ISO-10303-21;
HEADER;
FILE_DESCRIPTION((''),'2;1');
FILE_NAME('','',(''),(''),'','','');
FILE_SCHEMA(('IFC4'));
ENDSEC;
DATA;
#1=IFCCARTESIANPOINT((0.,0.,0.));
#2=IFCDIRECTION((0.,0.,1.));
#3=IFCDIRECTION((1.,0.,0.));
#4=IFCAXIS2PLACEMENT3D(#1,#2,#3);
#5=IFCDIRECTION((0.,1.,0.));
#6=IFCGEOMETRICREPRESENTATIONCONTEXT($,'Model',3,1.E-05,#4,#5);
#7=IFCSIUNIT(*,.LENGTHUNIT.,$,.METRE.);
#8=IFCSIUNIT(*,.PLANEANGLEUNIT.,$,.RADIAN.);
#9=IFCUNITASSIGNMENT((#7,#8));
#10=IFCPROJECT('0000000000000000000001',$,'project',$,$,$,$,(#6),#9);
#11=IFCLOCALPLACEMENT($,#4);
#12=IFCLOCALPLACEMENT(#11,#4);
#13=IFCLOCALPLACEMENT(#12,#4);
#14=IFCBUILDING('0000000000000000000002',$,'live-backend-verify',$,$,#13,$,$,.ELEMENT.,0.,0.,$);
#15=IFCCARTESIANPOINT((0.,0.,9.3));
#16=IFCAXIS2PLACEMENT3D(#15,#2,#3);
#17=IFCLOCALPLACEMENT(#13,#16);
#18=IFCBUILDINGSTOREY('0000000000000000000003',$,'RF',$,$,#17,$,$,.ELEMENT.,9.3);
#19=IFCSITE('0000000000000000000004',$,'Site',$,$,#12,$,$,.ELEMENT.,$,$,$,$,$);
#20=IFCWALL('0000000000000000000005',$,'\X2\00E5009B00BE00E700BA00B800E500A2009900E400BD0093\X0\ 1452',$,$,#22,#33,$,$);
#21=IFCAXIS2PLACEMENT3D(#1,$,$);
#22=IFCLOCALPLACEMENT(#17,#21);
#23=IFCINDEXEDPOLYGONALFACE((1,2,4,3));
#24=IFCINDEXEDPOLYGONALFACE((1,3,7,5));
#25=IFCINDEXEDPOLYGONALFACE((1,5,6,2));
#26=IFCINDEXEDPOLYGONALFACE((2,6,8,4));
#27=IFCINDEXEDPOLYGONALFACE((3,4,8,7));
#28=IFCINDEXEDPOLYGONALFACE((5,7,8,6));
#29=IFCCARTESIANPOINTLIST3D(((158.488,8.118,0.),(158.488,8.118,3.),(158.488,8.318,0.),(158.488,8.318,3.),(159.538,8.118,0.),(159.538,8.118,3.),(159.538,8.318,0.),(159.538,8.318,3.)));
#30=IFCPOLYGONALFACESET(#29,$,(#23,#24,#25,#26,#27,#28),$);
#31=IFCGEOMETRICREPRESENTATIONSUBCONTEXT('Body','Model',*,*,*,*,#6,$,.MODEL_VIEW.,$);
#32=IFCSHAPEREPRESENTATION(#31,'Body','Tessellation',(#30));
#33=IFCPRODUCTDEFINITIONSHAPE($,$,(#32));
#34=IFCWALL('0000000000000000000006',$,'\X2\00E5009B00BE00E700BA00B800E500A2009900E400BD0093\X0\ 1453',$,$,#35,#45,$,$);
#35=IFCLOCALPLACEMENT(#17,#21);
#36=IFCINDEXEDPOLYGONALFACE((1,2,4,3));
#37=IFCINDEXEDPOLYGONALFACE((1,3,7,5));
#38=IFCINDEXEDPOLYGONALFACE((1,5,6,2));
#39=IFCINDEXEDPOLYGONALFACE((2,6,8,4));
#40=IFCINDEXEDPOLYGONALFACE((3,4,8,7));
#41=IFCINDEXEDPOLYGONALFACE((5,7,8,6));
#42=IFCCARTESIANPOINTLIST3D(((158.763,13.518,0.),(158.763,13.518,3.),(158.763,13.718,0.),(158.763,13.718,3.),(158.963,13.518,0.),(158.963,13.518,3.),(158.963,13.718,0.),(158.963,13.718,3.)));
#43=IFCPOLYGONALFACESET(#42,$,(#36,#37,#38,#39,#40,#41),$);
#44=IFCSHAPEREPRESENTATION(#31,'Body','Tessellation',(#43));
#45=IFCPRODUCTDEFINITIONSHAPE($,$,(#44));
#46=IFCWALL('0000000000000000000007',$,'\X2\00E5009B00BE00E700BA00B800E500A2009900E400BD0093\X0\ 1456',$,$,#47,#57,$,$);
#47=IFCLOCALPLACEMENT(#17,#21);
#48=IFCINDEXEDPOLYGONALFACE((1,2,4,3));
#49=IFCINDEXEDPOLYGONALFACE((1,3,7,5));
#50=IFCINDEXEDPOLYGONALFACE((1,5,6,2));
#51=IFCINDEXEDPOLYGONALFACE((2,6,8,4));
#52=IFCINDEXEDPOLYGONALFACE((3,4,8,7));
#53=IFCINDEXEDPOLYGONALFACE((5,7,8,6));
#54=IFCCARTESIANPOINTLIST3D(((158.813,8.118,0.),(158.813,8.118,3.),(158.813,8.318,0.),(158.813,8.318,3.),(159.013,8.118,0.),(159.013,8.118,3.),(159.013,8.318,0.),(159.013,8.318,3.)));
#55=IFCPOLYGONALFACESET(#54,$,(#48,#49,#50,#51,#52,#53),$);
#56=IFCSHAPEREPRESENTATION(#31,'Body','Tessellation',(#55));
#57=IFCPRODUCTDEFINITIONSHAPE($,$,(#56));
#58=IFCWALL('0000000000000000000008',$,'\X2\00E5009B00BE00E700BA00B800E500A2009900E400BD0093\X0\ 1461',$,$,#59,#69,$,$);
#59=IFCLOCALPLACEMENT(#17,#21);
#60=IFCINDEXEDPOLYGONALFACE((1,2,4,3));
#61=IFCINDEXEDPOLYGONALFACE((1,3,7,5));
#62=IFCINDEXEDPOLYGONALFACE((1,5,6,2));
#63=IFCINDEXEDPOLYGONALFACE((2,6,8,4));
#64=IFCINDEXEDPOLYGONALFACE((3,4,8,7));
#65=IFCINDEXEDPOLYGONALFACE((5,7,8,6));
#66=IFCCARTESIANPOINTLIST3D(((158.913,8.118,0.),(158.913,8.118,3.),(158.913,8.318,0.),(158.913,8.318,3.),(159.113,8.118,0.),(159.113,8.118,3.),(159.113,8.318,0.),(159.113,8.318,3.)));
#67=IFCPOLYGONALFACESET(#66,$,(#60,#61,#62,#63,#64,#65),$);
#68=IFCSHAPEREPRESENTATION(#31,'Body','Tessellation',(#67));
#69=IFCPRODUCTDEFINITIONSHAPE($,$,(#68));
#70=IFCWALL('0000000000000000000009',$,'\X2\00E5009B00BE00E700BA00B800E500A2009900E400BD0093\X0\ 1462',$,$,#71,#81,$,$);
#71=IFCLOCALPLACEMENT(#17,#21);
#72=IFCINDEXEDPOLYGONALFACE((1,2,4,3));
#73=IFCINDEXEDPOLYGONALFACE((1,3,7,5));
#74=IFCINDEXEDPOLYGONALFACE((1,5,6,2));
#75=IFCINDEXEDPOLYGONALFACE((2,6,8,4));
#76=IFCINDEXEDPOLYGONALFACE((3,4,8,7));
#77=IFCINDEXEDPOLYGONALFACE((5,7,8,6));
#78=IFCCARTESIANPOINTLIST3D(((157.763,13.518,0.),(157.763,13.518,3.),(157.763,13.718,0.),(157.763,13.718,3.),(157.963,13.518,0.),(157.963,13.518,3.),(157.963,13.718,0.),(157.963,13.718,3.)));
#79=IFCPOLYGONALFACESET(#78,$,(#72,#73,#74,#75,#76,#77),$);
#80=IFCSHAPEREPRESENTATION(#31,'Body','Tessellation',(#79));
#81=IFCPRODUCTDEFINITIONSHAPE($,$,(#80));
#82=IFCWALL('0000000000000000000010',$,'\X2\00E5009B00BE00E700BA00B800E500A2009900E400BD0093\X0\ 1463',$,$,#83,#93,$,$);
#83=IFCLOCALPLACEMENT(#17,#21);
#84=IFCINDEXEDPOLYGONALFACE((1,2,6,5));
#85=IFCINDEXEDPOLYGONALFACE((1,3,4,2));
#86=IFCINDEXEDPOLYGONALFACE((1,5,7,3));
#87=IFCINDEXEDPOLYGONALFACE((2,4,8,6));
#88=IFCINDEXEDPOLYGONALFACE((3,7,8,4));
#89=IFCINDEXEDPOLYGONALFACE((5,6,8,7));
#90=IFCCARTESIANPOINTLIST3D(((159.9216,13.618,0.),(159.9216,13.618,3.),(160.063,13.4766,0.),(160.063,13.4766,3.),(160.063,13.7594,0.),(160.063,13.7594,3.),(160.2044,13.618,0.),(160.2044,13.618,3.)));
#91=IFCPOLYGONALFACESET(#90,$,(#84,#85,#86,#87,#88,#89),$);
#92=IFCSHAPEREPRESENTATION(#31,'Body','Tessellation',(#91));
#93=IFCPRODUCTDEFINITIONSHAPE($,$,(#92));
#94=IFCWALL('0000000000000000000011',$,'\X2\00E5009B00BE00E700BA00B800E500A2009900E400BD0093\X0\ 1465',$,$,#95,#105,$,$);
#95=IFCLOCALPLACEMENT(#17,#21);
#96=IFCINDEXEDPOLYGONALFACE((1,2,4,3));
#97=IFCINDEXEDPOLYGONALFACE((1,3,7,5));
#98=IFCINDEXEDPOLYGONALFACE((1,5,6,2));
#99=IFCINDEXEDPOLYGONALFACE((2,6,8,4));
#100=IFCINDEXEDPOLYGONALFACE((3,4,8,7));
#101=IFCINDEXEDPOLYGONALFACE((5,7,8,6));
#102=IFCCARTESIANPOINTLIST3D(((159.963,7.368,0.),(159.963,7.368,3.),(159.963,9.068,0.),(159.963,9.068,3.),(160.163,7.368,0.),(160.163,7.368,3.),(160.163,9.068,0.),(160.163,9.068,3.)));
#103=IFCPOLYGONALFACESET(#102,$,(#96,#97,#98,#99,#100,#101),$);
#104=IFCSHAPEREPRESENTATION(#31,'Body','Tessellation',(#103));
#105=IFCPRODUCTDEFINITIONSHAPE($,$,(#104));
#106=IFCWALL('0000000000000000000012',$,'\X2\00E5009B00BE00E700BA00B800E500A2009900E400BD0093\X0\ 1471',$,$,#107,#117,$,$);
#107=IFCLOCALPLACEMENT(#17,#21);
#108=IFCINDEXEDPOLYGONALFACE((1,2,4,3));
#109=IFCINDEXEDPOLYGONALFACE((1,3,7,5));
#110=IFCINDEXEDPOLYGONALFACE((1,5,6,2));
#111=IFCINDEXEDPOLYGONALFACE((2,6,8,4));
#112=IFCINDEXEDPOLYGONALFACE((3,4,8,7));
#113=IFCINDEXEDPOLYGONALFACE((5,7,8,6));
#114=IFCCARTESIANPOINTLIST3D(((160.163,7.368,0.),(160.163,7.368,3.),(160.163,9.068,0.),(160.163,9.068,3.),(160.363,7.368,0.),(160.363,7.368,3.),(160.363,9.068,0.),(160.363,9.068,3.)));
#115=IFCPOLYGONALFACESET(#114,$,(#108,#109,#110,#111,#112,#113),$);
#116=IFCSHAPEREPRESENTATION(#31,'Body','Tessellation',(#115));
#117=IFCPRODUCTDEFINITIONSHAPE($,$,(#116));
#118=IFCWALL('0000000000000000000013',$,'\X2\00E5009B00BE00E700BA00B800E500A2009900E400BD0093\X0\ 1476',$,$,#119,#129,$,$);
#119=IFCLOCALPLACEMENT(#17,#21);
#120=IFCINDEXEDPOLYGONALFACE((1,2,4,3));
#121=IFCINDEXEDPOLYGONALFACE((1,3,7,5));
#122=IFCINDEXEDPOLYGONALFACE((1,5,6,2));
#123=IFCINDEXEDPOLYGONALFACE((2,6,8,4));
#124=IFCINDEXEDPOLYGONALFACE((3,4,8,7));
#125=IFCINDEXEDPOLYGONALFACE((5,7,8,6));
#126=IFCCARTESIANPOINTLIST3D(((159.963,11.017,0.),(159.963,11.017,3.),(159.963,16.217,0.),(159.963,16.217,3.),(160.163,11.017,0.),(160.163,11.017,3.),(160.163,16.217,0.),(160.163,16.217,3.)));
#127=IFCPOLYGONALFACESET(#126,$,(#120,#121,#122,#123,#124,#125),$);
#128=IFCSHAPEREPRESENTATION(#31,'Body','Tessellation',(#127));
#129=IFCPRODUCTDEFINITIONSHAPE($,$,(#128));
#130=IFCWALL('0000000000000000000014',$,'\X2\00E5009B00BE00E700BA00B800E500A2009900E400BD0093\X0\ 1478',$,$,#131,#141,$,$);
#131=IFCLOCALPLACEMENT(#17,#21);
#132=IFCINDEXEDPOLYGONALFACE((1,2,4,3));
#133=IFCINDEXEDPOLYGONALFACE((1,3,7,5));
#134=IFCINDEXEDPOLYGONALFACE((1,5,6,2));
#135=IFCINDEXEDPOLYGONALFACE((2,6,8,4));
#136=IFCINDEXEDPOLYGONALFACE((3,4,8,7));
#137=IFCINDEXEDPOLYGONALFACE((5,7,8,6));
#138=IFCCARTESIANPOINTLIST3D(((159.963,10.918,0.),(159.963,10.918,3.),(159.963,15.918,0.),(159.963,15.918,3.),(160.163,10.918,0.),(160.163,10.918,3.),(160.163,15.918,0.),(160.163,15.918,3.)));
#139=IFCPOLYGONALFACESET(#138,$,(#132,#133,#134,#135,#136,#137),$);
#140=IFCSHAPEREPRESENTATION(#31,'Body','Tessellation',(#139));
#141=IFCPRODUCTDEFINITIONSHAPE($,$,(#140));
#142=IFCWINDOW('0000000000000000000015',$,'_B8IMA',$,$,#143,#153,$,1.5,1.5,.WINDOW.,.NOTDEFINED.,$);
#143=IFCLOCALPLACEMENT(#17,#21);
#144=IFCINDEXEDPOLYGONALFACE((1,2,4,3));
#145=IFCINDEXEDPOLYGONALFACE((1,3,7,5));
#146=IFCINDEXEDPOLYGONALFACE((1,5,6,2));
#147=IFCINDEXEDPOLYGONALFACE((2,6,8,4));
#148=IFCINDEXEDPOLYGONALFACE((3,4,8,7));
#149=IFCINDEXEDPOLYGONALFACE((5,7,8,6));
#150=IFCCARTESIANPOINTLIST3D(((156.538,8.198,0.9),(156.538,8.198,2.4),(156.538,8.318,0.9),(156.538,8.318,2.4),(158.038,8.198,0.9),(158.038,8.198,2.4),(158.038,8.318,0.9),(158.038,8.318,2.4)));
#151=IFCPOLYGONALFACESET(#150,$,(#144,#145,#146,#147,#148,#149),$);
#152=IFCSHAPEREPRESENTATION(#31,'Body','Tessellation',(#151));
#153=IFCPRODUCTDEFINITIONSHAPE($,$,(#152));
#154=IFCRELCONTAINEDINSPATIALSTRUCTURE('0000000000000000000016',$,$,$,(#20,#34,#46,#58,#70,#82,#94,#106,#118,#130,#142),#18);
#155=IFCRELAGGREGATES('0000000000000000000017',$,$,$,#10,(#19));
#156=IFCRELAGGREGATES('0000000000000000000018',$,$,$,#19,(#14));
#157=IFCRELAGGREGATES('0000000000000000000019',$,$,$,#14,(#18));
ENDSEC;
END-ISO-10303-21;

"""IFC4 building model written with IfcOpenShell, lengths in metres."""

from ifc_helpers import new_model, si_unit, direction, frame, frame_2d, origin_with_axes, place, context, subcontext, project, spatial, rectangle, extrude, element, save


model = new_model("IFC4")

# Units and contexts
model_context = context("Model", 3, precision=1e-05, world=origin_with_axes(), true_north=direction((0.0, 1.0, 0.0)))
body_context = subcontext(model_context, "Body", "Model", "MODEL_VIEW")
ifc_project = project(units=[si_unit("LENGTHUNIT", "METRE"), si_unit("PLANEANGLEUNIT", "RADIAN")], contexts=[model_context])

# Site, building, storey
placement = place(None, origin_with_axes())
site_placement = place(placement, origin_with_axes())
site = spatial("IfcSite", under=ifc_project, at=site_placement, Name="Site", CompositionType="ELEMENT")
building_placement = place(site_placement, origin_with_axes())
building = spatial("IfcBuilding", under=site, at=building_placement, Name="live-backend-verify", CompositionType="ELEMENT", ElevationOfRefHeight=0.0, ElevationOfTerrain=0.0)
storey_placement = place(building_placement, frame((0.0, 0.0, 9.3), z_axis=(0.0, 0.0, 1.0), x_axis=(1.0, 0.0, 0.0)))
storey = spatial("IfcBuildingStorey", under=building, at=storey_placement, Name="RF", CompositionType="ELEMENT", Elevation=9.3)

# Walls
wall_1_placement = place(storey_placement, frame((159.013, 8.218, 0.0), z_axis=(0.0, 0.0, 1.0), x_axis=(1.0, 0.0, 0.0)))
element("IfcWall", 1, at=wall_1_placement, inside=storey, Name="å\u009b¾çº¸å¢\u0099ä½\u0093 1452", context=body_context, shape_type="SweptSolid", body=[
    extrude(rectangle(XDim=1.05, YDim=0.2, at=frame_2d((0.0, 0.0), x_axis=(1.0, 0.0, 0.0))), frame((0.0, 0.0, 0.0), z_axis=(0.0, 0.0, 1.0)), (0.0, 0.0, 1.0), 3.0),
])
for number, where, z_axis, x_axis, name in (
    (2, (158.863, 13.618, 0.0), (0.0, 0.0, 1.0), (0.0, 1.0, 0.0), "å\u009b¾çº¸å¢\u0099ä½\u0093 1453"),
    (3, (158.913, 8.218, 0.0), (0.0, 0.0, 1.0), (0.0, 1.0, 0.0), "å\u009b¾çº¸å¢\u0099ä½\u0093 1456"),
    (4, (159.013, 8.218, 0.0), (0.0, 0.0, 1.0), (0.0, -1.0, 0.0), "å\u009b¾çº¸å¢\u0099ä½\u0093 1461"),
    (5, (157.863, 13.618, 0.0), (0.0, 0.0, 1.0), (0.0, 1.0, 0.0), "å\u009b¾çº¸å¢\u0099ä½\u0093 1462"),
    (6, (160.063, 13.618, 0.0), (0.0, 0.0, 1.0), (0.707107, -0.707107, 0.0), "å\u009b¾çº¸å¢\u0099ä½\u0093 1463"),
):
    element("IfcWall", number, at=place(storey_placement, frame(where, z_axis=z_axis, x_axis=x_axis)), inside=storey, Name=name, context=body_context, shape_type="SweptSolid", body=[
        extrude(rectangle(XDim=0.2, YDim=0.2, at=frame_2d((0.0, 0.0), x_axis=(1.0, 0.0, 0.0))), frame((0.0, 0.0, 0.0), z_axis=(0.0, 0.0, 1.0)), (0.0, 0.0, 1.0), 3.0),
    ])
for number, where, z_axis, x_axis, name in (
    (7, (160.063, 8.218, 0.0), (0.0, 0.0, 1.0), (0.0, -1.0, 0.0), "å\u009b¾çº¸å¢\u0099ä½\u0093 1465"),
    (8, (160.263, 8.218, 0.0), (0.0, 0.0, 1.0), (0.0, -1.0, 0.0), "å\u009b¾çº¸å¢\u0099ä½\u0093 1471"),
):
    element("IfcWall", number, at=place(storey_placement, frame(where, z_axis=z_axis, x_axis=x_axis)), inside=storey, Name=name, context=body_context, shape_type="SweptSolid", body=[
        extrude(rectangle(XDim=1.7, YDim=0.2, at=frame_2d((0.0, 0.0), x_axis=(1.0, 0.0, 0.0))), frame((0.0, 0.0, 0.0), z_axis=(0.0, 0.0, 1.0)), (0.0, 0.0, 1.0), 3.0),
    ])
wall_2_placement = place(storey_placement, frame((160.063, 13.617, 0.0), z_axis=(0.0, 0.0, 1.0), x_axis=(0.0, -1.0, 0.0)))
element("IfcWall", 9, at=wall_2_placement, inside=storey, Name="å\u009b¾çº¸å¢\u0099ä½\u0093 1476", context=body_context, shape_type="SweptSolid", body=[
    extrude(rectangle(XDim=5.2, YDim=0.2, at=frame_2d((0.0, 0.0), x_axis=(1.0, 0.0, 0.0))), frame((0.0, 0.0, 0.0), z_axis=(0.0, 0.0, 1.0)), (0.0, 0.0, 1.0), 3.0),
])
wall_3_placement = place(storey_placement, frame((160.063, 13.418, 0.0), z_axis=(0.0, 0.0, 1.0), x_axis=(0.0, -1.0, 0.0)))
element("IfcWall", 10, at=wall_3_placement, inside=storey, Name="å\u009b¾çº¸å¢\u0099ä½\u0093 1478", context=body_context, shape_type="SweptSolid", body=[
    extrude(rectangle(XDim=5.0, YDim=0.2, at=frame_2d((0.0, 0.0), x_axis=(1.0, 0.0, 0.0))), frame((0.0, 0.0, 0.0), z_axis=(0.0, 0.0, 1.0)), (0.0, 0.0, 1.0), 3.0),
])

# Window
window_placement = place(storey_placement, frame((157.288, 8.258, 0.9), z_axis=(0.0, 0.0, 1.0), x_axis=(1.0, 0.0, 0.0)))
element("IfcWindow", 11, at=window_placement, inside=storey, Name="_B8IMA", OverallHeight=1.5, OverallWidth=1.5, PartitioningType="NOTDEFINED", PredefinedType="WINDOW", context=body_context, shape_type="SweptSolid", body=[
    extrude(rectangle(XDim=1.5, YDim=0.12, at=frame_2d((0.0, 0.0), x_axis=(1.0, 0.0, 0.0))), frame((0.0, 0.0, 0.0), z_axis=(0.0, 0.0, 1.0)), (0.0, 0.0, 1.0), 1.5),
])

save(model, "model.ifc")
